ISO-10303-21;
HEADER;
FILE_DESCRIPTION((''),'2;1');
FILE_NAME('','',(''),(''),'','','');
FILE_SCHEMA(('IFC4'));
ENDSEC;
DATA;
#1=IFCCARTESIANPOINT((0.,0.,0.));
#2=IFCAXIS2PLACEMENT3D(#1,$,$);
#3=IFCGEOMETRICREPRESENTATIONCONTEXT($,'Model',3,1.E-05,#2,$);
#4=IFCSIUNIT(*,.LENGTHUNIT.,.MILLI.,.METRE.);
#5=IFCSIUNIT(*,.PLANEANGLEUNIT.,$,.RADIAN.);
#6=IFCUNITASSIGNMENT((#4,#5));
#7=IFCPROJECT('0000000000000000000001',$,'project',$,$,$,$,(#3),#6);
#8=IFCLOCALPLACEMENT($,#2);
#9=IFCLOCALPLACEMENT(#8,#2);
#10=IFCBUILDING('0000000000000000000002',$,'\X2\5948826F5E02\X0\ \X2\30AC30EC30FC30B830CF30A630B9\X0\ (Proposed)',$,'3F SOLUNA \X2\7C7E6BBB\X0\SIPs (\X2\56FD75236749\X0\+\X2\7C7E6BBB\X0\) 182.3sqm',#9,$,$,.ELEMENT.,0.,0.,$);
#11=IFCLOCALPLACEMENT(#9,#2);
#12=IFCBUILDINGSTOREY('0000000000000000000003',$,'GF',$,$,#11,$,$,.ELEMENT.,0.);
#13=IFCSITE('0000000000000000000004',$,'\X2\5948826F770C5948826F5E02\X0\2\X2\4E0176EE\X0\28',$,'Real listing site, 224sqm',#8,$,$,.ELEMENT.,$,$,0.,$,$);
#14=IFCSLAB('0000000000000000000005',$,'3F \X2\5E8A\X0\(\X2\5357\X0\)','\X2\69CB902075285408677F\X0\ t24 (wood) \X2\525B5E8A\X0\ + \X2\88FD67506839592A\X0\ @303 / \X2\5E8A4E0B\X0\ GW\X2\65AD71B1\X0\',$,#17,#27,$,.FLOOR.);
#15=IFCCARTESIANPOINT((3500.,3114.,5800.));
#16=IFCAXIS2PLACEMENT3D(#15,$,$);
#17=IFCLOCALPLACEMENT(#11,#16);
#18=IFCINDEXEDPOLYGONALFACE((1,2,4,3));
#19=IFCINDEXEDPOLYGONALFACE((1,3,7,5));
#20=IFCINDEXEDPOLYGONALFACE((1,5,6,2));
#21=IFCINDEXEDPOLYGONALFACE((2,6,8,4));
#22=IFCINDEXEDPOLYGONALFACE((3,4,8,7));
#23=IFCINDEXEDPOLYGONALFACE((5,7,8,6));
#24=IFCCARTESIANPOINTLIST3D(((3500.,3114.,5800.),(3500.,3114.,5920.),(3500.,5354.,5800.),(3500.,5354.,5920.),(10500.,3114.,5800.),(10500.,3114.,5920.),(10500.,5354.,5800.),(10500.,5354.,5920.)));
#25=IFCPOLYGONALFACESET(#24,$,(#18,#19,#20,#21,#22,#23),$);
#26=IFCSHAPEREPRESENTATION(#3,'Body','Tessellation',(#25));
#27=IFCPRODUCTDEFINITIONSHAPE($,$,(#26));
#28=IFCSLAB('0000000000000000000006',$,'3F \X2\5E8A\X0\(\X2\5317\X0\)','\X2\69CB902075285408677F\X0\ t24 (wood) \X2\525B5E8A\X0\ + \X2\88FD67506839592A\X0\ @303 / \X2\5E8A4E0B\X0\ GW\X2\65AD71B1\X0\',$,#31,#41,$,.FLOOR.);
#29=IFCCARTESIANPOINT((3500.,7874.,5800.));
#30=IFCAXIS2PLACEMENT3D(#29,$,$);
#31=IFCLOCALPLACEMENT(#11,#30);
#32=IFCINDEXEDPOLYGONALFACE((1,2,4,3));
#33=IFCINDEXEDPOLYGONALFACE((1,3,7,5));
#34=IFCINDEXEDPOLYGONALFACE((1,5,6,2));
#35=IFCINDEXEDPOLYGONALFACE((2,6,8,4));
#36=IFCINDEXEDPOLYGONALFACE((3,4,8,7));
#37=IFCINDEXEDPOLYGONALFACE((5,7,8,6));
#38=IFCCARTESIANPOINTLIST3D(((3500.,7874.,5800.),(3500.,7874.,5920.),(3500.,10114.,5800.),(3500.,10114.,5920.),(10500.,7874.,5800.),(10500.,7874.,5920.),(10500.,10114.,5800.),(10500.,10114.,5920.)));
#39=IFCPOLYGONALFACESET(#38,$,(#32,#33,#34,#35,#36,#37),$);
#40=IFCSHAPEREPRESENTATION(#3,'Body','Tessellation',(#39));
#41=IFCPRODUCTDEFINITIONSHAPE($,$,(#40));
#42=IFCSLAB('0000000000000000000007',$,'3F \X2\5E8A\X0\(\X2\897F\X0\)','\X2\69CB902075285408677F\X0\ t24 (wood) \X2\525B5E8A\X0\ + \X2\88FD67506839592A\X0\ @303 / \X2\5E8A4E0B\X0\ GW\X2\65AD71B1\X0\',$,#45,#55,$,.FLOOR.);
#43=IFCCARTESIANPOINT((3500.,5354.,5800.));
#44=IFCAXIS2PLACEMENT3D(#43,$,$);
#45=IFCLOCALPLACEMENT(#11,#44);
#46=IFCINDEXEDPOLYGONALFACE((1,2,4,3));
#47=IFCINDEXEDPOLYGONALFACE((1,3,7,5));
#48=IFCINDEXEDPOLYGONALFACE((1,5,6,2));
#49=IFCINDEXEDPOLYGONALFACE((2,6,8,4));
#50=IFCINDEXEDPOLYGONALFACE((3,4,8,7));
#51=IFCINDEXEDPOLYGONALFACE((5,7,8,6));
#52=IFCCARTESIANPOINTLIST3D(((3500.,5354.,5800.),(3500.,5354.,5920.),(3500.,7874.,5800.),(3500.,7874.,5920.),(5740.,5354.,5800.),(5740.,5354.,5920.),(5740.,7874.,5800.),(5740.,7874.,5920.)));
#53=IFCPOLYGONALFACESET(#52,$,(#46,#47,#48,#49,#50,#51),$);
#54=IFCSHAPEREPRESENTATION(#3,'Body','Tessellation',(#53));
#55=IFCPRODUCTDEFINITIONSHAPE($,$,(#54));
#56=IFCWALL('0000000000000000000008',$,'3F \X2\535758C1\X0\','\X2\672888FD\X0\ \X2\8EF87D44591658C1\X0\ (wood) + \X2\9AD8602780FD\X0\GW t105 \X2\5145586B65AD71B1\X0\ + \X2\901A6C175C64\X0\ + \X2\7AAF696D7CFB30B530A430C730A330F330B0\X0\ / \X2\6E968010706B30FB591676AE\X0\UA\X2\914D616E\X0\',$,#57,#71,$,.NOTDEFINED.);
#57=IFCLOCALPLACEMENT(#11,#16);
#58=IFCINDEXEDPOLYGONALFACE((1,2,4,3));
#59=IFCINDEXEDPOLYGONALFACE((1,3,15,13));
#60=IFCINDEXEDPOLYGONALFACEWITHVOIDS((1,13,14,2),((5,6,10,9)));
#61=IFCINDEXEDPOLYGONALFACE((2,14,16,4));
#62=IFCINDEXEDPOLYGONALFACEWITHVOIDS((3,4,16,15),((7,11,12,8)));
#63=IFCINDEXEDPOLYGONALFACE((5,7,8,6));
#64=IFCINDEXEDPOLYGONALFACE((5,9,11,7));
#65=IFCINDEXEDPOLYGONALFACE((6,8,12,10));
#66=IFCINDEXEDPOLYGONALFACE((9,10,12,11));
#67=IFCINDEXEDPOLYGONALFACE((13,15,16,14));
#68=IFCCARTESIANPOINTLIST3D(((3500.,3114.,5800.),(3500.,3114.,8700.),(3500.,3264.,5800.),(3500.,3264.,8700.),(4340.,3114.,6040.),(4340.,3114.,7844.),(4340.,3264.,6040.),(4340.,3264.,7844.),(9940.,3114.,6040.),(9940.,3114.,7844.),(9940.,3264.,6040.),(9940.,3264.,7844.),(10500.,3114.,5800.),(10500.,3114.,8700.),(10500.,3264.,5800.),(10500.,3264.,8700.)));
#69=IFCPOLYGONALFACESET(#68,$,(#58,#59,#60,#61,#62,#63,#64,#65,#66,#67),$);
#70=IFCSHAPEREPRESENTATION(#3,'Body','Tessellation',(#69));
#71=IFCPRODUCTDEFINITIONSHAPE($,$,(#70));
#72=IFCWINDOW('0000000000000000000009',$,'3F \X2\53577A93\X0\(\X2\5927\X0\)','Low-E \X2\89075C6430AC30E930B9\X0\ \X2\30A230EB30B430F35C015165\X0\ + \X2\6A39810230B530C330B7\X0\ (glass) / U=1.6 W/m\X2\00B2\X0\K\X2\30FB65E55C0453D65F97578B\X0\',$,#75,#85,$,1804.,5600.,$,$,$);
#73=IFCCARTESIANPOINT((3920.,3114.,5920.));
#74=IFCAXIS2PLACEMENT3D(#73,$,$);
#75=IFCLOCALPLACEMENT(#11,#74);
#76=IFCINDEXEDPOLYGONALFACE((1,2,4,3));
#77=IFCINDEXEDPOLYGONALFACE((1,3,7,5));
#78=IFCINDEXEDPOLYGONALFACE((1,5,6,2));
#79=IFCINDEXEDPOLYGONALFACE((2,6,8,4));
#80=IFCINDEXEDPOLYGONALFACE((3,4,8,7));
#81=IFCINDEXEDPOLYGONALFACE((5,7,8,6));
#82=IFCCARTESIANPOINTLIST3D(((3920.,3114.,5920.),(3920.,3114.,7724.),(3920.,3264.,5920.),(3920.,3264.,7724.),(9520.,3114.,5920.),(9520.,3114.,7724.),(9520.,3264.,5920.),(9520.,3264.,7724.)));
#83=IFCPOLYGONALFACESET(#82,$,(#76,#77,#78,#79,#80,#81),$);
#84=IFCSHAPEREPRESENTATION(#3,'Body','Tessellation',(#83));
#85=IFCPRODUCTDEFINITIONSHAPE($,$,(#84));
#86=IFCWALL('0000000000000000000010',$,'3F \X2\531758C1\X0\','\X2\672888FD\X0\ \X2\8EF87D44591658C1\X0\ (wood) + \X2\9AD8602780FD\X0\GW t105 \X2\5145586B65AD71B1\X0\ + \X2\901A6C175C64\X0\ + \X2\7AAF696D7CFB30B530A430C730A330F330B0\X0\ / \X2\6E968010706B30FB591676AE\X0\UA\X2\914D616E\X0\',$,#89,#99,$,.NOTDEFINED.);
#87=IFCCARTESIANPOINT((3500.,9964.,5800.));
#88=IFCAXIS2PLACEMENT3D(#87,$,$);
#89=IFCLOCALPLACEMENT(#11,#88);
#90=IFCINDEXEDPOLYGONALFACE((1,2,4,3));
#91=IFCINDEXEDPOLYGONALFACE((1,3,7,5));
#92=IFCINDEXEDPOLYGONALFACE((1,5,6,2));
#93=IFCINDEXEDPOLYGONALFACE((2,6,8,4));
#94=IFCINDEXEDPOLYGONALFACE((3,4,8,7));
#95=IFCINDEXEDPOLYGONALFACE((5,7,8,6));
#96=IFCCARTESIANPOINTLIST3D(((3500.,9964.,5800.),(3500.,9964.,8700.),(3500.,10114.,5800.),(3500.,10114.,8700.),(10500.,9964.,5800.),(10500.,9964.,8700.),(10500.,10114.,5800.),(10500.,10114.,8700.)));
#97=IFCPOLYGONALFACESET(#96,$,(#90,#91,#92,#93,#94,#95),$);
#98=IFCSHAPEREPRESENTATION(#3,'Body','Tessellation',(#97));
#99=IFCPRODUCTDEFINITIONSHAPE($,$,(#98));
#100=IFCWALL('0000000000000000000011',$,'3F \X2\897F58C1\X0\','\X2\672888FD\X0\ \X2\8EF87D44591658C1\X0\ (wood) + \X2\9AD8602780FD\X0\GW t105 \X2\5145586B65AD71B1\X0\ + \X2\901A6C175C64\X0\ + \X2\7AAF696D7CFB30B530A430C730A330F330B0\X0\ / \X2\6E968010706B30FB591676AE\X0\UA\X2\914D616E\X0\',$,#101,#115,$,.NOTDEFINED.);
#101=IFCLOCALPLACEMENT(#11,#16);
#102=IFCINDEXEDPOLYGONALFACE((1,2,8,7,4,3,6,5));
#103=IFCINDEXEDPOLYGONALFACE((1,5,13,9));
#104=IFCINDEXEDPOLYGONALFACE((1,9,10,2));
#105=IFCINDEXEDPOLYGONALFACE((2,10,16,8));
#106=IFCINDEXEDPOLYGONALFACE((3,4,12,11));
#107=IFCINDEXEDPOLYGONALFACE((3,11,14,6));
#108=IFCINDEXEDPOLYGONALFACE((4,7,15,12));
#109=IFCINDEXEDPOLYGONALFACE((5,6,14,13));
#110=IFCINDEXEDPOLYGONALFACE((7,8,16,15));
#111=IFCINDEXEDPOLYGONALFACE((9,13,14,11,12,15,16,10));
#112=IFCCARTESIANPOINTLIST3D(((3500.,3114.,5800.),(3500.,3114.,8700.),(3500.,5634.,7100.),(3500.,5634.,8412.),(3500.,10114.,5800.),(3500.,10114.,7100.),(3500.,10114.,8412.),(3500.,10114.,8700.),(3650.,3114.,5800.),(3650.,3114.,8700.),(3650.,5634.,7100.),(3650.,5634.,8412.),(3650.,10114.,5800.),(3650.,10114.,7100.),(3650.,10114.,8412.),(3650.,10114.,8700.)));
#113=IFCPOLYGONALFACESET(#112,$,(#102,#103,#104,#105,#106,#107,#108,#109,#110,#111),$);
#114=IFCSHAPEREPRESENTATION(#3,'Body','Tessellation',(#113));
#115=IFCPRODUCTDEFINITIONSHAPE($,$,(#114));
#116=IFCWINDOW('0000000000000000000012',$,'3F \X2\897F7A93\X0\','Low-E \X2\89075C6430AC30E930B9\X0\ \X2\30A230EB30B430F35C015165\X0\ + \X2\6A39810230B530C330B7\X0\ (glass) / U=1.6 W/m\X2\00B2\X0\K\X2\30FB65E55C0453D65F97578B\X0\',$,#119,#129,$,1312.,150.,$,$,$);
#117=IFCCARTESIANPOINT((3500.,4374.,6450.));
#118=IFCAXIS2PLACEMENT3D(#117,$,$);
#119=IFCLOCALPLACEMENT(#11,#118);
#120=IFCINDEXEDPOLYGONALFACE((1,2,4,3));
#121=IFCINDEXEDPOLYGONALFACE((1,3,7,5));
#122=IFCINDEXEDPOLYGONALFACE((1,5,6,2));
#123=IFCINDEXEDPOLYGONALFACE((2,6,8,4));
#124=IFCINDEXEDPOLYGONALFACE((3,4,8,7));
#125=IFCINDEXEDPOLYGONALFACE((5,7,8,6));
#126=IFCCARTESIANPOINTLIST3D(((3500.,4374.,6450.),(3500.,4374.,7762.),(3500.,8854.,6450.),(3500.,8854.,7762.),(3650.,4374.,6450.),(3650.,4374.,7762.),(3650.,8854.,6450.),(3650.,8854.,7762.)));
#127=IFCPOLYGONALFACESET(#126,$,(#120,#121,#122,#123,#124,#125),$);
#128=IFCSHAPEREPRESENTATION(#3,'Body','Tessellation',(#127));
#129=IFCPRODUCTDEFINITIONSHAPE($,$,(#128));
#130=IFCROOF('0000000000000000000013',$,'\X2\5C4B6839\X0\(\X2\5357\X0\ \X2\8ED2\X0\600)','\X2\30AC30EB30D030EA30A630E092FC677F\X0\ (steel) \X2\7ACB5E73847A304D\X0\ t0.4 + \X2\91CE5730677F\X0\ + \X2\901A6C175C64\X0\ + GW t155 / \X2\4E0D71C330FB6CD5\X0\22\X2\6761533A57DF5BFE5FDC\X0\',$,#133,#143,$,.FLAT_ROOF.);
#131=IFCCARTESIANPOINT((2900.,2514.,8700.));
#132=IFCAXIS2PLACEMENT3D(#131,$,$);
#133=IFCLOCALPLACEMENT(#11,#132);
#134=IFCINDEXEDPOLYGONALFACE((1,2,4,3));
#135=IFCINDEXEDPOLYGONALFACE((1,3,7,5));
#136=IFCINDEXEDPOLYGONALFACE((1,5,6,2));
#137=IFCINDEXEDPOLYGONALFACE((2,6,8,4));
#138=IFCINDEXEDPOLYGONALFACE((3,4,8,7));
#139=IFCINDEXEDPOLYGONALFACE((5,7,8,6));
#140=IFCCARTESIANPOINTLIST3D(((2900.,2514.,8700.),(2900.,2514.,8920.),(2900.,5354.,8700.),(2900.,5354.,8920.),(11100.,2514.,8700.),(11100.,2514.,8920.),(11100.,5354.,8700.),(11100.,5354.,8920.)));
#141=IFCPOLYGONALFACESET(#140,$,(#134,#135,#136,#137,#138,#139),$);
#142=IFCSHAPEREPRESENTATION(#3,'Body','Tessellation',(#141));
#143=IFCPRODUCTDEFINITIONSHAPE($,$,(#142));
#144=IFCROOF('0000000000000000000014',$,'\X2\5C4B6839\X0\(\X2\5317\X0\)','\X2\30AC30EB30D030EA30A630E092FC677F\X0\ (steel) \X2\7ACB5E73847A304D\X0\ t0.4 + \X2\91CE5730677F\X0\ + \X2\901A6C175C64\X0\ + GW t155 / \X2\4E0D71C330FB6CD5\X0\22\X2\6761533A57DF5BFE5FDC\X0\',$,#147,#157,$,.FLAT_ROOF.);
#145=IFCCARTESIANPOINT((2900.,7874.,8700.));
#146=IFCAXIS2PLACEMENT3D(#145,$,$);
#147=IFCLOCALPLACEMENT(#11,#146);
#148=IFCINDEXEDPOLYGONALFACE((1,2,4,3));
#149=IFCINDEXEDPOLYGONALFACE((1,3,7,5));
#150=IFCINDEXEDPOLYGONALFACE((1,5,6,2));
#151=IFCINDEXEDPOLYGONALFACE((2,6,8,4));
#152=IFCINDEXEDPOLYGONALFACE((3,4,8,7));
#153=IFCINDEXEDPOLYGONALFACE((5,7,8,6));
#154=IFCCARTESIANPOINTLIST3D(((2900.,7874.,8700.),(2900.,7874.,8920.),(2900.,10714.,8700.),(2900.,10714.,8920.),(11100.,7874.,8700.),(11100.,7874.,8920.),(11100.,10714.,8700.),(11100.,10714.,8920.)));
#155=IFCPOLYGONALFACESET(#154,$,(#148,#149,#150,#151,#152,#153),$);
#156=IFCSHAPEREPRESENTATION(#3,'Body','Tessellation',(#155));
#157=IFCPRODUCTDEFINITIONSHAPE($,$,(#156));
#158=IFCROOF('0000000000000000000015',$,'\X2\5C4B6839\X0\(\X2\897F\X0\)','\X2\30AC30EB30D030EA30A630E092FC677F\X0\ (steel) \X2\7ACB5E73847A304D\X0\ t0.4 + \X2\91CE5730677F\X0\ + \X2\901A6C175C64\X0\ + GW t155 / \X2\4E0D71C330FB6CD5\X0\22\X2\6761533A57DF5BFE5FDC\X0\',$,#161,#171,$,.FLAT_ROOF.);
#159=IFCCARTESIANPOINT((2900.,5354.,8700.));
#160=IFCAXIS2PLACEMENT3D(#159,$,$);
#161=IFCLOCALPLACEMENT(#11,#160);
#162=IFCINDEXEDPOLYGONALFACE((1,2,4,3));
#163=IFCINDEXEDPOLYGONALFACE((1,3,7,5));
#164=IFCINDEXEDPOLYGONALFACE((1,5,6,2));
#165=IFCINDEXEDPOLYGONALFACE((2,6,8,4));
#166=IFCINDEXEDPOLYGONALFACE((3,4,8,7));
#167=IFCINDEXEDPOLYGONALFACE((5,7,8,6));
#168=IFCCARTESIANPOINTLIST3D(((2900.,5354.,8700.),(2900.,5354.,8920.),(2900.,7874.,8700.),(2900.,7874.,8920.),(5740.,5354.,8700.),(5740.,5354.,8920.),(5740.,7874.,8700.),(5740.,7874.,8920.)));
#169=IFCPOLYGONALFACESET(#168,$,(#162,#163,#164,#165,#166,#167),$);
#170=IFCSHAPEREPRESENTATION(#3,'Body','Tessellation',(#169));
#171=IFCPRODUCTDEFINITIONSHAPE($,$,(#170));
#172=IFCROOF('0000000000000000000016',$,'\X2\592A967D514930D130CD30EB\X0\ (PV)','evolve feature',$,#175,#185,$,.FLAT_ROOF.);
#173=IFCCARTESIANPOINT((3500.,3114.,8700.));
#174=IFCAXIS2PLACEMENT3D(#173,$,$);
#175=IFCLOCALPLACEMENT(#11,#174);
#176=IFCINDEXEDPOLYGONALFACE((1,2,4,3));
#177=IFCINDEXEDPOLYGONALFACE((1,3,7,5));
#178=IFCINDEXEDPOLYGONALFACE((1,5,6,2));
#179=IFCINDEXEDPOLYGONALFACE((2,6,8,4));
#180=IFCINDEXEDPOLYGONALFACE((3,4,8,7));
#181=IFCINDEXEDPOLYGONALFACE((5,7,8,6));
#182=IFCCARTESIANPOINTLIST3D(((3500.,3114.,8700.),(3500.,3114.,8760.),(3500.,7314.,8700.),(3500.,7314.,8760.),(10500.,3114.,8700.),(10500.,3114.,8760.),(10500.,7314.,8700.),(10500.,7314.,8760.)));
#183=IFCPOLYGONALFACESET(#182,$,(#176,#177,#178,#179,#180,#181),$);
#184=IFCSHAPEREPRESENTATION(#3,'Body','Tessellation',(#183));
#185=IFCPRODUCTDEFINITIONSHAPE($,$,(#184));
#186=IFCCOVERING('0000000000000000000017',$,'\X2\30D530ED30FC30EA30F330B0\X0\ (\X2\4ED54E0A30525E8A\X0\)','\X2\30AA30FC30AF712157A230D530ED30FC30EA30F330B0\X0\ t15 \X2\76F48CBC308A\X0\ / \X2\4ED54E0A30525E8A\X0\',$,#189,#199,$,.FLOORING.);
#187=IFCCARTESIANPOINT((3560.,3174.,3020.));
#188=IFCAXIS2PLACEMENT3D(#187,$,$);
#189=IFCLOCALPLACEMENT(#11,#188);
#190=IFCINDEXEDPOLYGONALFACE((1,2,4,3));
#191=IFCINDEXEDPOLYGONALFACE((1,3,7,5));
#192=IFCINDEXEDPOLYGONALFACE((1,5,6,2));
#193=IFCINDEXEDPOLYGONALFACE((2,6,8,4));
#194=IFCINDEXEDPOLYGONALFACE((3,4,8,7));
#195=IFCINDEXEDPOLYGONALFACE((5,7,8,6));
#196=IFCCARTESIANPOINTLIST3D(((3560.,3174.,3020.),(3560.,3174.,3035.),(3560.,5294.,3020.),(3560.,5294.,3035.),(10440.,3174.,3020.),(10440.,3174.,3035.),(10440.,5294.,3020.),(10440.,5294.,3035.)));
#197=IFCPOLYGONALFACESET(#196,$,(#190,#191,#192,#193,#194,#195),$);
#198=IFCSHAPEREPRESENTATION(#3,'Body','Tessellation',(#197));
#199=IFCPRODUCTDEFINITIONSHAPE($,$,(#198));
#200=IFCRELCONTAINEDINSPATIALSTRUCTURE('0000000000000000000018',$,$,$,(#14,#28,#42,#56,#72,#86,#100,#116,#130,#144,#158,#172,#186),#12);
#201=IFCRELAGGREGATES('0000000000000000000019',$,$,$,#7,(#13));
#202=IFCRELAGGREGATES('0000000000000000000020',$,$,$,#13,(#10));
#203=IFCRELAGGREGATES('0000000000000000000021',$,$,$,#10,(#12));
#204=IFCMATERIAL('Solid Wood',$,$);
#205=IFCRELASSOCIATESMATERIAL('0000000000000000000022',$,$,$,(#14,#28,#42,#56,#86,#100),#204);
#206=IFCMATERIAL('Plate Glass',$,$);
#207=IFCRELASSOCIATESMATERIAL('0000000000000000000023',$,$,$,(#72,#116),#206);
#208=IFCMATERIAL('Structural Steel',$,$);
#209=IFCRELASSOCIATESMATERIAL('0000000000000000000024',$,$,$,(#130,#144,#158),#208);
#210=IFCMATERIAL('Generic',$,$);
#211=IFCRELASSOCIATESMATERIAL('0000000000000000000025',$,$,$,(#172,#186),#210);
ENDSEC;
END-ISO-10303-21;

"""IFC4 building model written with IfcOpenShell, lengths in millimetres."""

from ifc_helpers import new_model, si_unit, frame, frame_2d, origin, place, context, project, spatial, rectangle, extrude, material, element, fill, save


model = new_model("IFC4")

# Units and contexts
model_context = context("Model", 3, precision=1e-05, world=origin())
ifc_project = project(units=[si_unit("LENGTHUNIT", "METRE", prefix="MILLI"), si_unit("PLANEANGLEUNIT", "RADIAN")], contexts=[model_context])

# Site, building, storey
site_placement = place(None, origin())
site = spatial("IfcSite", under=ifc_project, at=site_placement, Name="奈良県奈良市2丁目28", ObjectType="Real listing site, 224sqm", CompositionType="ELEMENT", RefElevation=0.0)
building_placement = place(site_placement, origin())
building = spatial("IfcBuilding", under=site, at=building_placement, Name="奈良市 ガレージハウス (Proposed)", ObjectType="3F SOLUNA 籾殻SIPs (国産杉+籾殻) 182.3sqm", CompositionType="ELEMENT", ElevationOfRefHeight=0.0, ElevationOfTerrain=0.0)
storey_placement = place(building_placement, origin())
storey = spatial("IfcBuildingStorey", under=building, at=storey_placement, Name="GF", CompositionType="ELEMENT", Elevation=0.0)

# Slabs
ifc_material_1 = material(Name="Solid Wood")
slab_1_placement = place(storey_placement, frame((3500.0, 3114.0, 5800.0)))
element("IfcSlab", 1, at=slab_1_placement, inside=storey, material=ifc_material_1, Name="3F 床(南)", Description="構造用合板 t24 (wood) 剛床 + 製材根太 @303 / 床下 GW断熱", PredefinedType="FLOOR", context=model_context, shape_type="SweptSolid", body=[
    extrude(rectangle(XDim=7000.0, YDim=2240.0, at=frame_2d((3500.0, 1120.0))), frame((3500.0, 3114.0, 5800.0)), (0.0, 0.0, 1.0), 120.0),
])
slab_2_placement = place(storey_placement, frame((3500.0, 7874.0, 5800.0)))
element("IfcSlab", 2, at=slab_2_placement, inside=storey, material=ifc_material_1, Name="3F 床(北)", Description="構造用合板 t24 (wood) 剛床 + 製材根太 @303 / 床下 GW断熱", PredefinedType="FLOOR", context=model_context, shape_type="SweptSolid", body=[
    extrude(rectangle(XDim=7000.0, YDim=2240.0, at=frame_2d((3500.0, 1120.0))), frame((3500.0, 7874.0, 5800.0)), (0.0, 0.0, 1.0), 120.0),
])
slab_3_placement = place(storey_placement, frame((3500.0, 5354.0, 5800.0)))
element("IfcSlab", 3, at=slab_3_placement, inside=storey, material=ifc_material_1, Name="3F 床(西)", Description="構造用合板 t24 (wood) 剛床 + 製材根太 @303 / 床下 GW断熱", PredefinedType="FLOOR", context=model_context, shape_type="SweptSolid", body=[
    extrude(rectangle(XDim=2240.0, YDim=2520.0, at=frame_2d((1120.0, 1260.0))), frame((3500.0, 5354.0, 5800.0)), (0.0, 0.0, 1.0), 120.0),
])

# Wall, opening, window
wall_1_placement = place(storey_placement, frame((3500.0, 3114.0, 5800.0)))
wall_1 = element("IfcWall", 4, at=wall_1_placement, inside=storey, material=ifc_material_1, Name="3F 南壁", Description="木製 軸組外壁 (wood) + 高性能GW t105 充填断熱 + 通気層 + 窯業系サイディング / 準耐火・外皮UA配慮", PredefinedType="NOTDEFINED", context=model_context, shape_type="SweptSolid", body=[
    extrude(rectangle(XDim=7000.0, YDim=150.0, at=frame_2d((3500.0, 75.0))), frame((3500.0, 3114.0, 5800.0)), (0.0, 0.0, 1.0), 2900.0),
])
opening_1_placement = place(storey_placement, frame((3920.0, 3114.0, 5920.0)))
opening_1 = element("IfcOpeningElement", 5, at=opening_1_placement, cuts=wall_1, PredefinedType="NOTDEFINED", context=model_context, shape_type="SweptSolid", body=[
    extrude(rectangle(XDim=5600.0, YDim=150.0, at=frame_2d((2800.0, 75.0))), frame((3920.0, 3114.0, 5920.0)), (0.0, 0.0, 1.0), 1804.0),
])
ifc_material_2 = material(Name="Plate Glass")
window_1_placement = place(storey_placement, frame((3920.0, 3114.0, 5920.0)))
window_1 = element("IfcWindow", 6, at=window_1_placement, inside=storey, material=ifc_material_2, Name="3F 南窓(大)", Description="Low-E 複層ガラス アルゴン封入 + 樹脂サッシ (glass) / U=1.6 W/m²K・日射取得型", OverallHeight=1804.0, OverallWidth=5600.0, context=model_context, shape_type="SweptSolid", body=[
    extrude(rectangle(XDim=5600.0, YDim=150.0, at=frame_2d((2800.0, 75.0))), frame((3920.0, 3114.0, 5920.0)), (0.0, 0.0, 1.0), 1804.0),
])
fill(opening_1, window_1)

# Wall
wall_2_placement = place(storey_placement, frame((3500.0, 9964.0, 5800.0)))
element("IfcWall", 7, at=wall_2_placement, inside=storey, material=ifc_material_1, Name="3F 北壁", Description="木製 軸組外壁 (wood) + 高性能GW t105 充填断熱 + 通気層 + 窯業系サイディング / 準耐火・外皮UA配慮", PredefinedType="NOTDEFINED", context=model_context, shape_type="SweptSolid", body=[
    extrude(rectangle(XDim=7000.0, YDim=150.0, at=frame_2d((3500.0, 75.0))), frame((3500.0, 9964.0, 5800.0)), (0.0, 0.0, 1.0), 2900.0),
])

# Wall, opening, window
wall_3_placement = place(storey_placement, frame((3500.0, 3114.0, 5800.0)))
wall_3 = element("IfcWall", 8, at=wall_3_placement, inside=storey, material=ifc_material_1, Name="3F 西壁", Description="木製 軸組外壁 (wood) + 高性能GW t105 充填断熱 + 通気層 + 窯業系サイディング / 準耐火・外皮UA配慮", PredefinedType="NOTDEFINED", context=model_context, shape_type="SweptSolid", body=[
    extrude(rectangle(XDim=150.0, YDim=7000.0, at=frame_2d((75.0, 3500.0))), frame((3500.0, 3114.0, 5800.0)), (0.0, 0.0, 1.0), 2900.0),
])
opening_2_placement = place(storey_placement, frame((3500.0, 4374.0, 6450.0)))
opening_2 = element("IfcOpeningElement", 9, at=opening_2_placement, cuts=wall_3, PredefinedType="NOTDEFINED", context=model_context, shape_type="SweptSolid", body=[
    extrude(rectangle(XDim=150.0, YDim=4480.0, at=frame_2d((75.0, 2240.0))), frame((3500.0, 4374.0, 6450.0)), (0.0, 0.0, 1.0), 1312.0),
])
window_2_placement = place(storey_placement, frame((3500.0, 4374.0, 6450.0)))
window_2 = element("IfcWindow", 10, at=window_2_placement, inside=storey, material=ifc_material_2, Name="3F 西窓", Description="Low-E 複層ガラス アルゴン封入 + 樹脂サッシ (glass) / U=1.6 W/m²K・日射取得型", OverallHeight=1312.0, OverallWidth=150.0, context=model_context, shape_type="SweptSolid", body=[
    extrude(rectangle(XDim=150.0, YDim=4480.0, at=frame_2d((75.0, 2240.0))), frame((3500.0, 4374.0, 6450.0)), (0.0, 0.0, 1.0), 1312.0),
])
fill(opening_2, window_2)

# Roofs
ifc_material_3 = material(Name="Structural Steel")
roof_1_placement = place(storey_placement, frame((2900.0, 2514.0, 8700.0)))
element("IfcRoof", 11, at=roof_1_placement, inside=storey, material=ifc_material_3, Name="屋根(南 軒600)", Description="ガルバリウム鋼板 (steel) 立平葺き t0.4 + 野地板 + 通気層 + GW t155 / 不燃・法22条区域対応", PredefinedType="FLAT_ROOF", context=model_context, shape_type="SweptSolid", body=[
    extrude(rectangle(XDim=8200.0, YDim=2840.0, at=frame_2d((4100.0, 1420.0))), frame((2900.0, 2514.0, 8700.0)), (0.0, 0.0, 1.0), 220.0),
])
roof_2_placement = place(storey_placement, frame((2900.0, 7874.0, 8700.0)))
element("IfcRoof", 12, at=roof_2_placement, inside=storey, material=ifc_material_3, Name="屋根(北)", Description="ガルバリウム鋼板 (steel) 立平葺き t0.4 + 野地板 + 通気層 + GW t155 / 不燃・法22条区域対応", PredefinedType="FLAT_ROOF", context=model_context, shape_type="SweptSolid", body=[
    extrude(rectangle(XDim=8200.0, YDim=2840.0, at=frame_2d((4100.0, 1420.0))), frame((2900.0, 7874.0, 8700.0)), (0.0, 0.0, 1.0), 220.0),
])
roof_3_placement = place(storey_placement, frame((2900.0, 5354.0, 8700.0)))
element("IfcRoof", 13, at=roof_3_placement, inside=storey, material=ifc_material_3, Name="屋根(西)", Description="ガルバリウム鋼板 (steel) 立平葺き t0.4 + 野地板 + 通気層 + GW t155 / 不燃・法22条区域対応", PredefinedType="FLAT_ROOF", context=model_context, shape_type="SweptSolid", body=[
    extrude(rectangle(XDim=2840.0, YDim=2520.0, at=frame_2d((1420.0, 1260.0))), frame((2900.0, 5354.0, 8700.0)), (0.0, 0.0, 1.0), 220.0),
])
ifc_material_4 = material(Name="Generic")
roof_4_placement = place(storey_placement, frame((3500.0, 3114.0, 8700.0)))
element("IfcRoof", 14, at=roof_4_placement, inside=storey, material=ifc_material_4, Name="太陽光パネル (PV)", Description="evolve feature", PredefinedType="FLAT_ROOF", context=model_context, shape_type="SweptSolid", body=[
    extrude(rectangle(XDim=7000.0, YDim=4200.0, at=frame_2d((3500.0, 2100.0))), frame((3500.0, 3114.0, 8700.0)), (0.0, 0.0, 1.0), 60.0),
])

# Covering
covering_1_placement = place(storey_placement, frame((3560.0, 3174.0, 3020.0)))
element("IfcCovering", 15, at=covering_1_placement, inside=storey, material=ifc_material_4, Name="フローリング (仕上げ床)", Description="オーク無垢フローリング t15 直貼り / 仕上げ床", PredefinedType="FLOORING", context=model_context, shape_type="SweptSolid", body=[
    extrude(rectangle(XDim=6880.0, YDim=2120.0, at=frame_2d((3440.0, 1060.0))), frame((3560.0, 3174.0, 3020.0)), (0.0, 0.0, 1.0), 15.0),
])

save(model, "model.ifc")
